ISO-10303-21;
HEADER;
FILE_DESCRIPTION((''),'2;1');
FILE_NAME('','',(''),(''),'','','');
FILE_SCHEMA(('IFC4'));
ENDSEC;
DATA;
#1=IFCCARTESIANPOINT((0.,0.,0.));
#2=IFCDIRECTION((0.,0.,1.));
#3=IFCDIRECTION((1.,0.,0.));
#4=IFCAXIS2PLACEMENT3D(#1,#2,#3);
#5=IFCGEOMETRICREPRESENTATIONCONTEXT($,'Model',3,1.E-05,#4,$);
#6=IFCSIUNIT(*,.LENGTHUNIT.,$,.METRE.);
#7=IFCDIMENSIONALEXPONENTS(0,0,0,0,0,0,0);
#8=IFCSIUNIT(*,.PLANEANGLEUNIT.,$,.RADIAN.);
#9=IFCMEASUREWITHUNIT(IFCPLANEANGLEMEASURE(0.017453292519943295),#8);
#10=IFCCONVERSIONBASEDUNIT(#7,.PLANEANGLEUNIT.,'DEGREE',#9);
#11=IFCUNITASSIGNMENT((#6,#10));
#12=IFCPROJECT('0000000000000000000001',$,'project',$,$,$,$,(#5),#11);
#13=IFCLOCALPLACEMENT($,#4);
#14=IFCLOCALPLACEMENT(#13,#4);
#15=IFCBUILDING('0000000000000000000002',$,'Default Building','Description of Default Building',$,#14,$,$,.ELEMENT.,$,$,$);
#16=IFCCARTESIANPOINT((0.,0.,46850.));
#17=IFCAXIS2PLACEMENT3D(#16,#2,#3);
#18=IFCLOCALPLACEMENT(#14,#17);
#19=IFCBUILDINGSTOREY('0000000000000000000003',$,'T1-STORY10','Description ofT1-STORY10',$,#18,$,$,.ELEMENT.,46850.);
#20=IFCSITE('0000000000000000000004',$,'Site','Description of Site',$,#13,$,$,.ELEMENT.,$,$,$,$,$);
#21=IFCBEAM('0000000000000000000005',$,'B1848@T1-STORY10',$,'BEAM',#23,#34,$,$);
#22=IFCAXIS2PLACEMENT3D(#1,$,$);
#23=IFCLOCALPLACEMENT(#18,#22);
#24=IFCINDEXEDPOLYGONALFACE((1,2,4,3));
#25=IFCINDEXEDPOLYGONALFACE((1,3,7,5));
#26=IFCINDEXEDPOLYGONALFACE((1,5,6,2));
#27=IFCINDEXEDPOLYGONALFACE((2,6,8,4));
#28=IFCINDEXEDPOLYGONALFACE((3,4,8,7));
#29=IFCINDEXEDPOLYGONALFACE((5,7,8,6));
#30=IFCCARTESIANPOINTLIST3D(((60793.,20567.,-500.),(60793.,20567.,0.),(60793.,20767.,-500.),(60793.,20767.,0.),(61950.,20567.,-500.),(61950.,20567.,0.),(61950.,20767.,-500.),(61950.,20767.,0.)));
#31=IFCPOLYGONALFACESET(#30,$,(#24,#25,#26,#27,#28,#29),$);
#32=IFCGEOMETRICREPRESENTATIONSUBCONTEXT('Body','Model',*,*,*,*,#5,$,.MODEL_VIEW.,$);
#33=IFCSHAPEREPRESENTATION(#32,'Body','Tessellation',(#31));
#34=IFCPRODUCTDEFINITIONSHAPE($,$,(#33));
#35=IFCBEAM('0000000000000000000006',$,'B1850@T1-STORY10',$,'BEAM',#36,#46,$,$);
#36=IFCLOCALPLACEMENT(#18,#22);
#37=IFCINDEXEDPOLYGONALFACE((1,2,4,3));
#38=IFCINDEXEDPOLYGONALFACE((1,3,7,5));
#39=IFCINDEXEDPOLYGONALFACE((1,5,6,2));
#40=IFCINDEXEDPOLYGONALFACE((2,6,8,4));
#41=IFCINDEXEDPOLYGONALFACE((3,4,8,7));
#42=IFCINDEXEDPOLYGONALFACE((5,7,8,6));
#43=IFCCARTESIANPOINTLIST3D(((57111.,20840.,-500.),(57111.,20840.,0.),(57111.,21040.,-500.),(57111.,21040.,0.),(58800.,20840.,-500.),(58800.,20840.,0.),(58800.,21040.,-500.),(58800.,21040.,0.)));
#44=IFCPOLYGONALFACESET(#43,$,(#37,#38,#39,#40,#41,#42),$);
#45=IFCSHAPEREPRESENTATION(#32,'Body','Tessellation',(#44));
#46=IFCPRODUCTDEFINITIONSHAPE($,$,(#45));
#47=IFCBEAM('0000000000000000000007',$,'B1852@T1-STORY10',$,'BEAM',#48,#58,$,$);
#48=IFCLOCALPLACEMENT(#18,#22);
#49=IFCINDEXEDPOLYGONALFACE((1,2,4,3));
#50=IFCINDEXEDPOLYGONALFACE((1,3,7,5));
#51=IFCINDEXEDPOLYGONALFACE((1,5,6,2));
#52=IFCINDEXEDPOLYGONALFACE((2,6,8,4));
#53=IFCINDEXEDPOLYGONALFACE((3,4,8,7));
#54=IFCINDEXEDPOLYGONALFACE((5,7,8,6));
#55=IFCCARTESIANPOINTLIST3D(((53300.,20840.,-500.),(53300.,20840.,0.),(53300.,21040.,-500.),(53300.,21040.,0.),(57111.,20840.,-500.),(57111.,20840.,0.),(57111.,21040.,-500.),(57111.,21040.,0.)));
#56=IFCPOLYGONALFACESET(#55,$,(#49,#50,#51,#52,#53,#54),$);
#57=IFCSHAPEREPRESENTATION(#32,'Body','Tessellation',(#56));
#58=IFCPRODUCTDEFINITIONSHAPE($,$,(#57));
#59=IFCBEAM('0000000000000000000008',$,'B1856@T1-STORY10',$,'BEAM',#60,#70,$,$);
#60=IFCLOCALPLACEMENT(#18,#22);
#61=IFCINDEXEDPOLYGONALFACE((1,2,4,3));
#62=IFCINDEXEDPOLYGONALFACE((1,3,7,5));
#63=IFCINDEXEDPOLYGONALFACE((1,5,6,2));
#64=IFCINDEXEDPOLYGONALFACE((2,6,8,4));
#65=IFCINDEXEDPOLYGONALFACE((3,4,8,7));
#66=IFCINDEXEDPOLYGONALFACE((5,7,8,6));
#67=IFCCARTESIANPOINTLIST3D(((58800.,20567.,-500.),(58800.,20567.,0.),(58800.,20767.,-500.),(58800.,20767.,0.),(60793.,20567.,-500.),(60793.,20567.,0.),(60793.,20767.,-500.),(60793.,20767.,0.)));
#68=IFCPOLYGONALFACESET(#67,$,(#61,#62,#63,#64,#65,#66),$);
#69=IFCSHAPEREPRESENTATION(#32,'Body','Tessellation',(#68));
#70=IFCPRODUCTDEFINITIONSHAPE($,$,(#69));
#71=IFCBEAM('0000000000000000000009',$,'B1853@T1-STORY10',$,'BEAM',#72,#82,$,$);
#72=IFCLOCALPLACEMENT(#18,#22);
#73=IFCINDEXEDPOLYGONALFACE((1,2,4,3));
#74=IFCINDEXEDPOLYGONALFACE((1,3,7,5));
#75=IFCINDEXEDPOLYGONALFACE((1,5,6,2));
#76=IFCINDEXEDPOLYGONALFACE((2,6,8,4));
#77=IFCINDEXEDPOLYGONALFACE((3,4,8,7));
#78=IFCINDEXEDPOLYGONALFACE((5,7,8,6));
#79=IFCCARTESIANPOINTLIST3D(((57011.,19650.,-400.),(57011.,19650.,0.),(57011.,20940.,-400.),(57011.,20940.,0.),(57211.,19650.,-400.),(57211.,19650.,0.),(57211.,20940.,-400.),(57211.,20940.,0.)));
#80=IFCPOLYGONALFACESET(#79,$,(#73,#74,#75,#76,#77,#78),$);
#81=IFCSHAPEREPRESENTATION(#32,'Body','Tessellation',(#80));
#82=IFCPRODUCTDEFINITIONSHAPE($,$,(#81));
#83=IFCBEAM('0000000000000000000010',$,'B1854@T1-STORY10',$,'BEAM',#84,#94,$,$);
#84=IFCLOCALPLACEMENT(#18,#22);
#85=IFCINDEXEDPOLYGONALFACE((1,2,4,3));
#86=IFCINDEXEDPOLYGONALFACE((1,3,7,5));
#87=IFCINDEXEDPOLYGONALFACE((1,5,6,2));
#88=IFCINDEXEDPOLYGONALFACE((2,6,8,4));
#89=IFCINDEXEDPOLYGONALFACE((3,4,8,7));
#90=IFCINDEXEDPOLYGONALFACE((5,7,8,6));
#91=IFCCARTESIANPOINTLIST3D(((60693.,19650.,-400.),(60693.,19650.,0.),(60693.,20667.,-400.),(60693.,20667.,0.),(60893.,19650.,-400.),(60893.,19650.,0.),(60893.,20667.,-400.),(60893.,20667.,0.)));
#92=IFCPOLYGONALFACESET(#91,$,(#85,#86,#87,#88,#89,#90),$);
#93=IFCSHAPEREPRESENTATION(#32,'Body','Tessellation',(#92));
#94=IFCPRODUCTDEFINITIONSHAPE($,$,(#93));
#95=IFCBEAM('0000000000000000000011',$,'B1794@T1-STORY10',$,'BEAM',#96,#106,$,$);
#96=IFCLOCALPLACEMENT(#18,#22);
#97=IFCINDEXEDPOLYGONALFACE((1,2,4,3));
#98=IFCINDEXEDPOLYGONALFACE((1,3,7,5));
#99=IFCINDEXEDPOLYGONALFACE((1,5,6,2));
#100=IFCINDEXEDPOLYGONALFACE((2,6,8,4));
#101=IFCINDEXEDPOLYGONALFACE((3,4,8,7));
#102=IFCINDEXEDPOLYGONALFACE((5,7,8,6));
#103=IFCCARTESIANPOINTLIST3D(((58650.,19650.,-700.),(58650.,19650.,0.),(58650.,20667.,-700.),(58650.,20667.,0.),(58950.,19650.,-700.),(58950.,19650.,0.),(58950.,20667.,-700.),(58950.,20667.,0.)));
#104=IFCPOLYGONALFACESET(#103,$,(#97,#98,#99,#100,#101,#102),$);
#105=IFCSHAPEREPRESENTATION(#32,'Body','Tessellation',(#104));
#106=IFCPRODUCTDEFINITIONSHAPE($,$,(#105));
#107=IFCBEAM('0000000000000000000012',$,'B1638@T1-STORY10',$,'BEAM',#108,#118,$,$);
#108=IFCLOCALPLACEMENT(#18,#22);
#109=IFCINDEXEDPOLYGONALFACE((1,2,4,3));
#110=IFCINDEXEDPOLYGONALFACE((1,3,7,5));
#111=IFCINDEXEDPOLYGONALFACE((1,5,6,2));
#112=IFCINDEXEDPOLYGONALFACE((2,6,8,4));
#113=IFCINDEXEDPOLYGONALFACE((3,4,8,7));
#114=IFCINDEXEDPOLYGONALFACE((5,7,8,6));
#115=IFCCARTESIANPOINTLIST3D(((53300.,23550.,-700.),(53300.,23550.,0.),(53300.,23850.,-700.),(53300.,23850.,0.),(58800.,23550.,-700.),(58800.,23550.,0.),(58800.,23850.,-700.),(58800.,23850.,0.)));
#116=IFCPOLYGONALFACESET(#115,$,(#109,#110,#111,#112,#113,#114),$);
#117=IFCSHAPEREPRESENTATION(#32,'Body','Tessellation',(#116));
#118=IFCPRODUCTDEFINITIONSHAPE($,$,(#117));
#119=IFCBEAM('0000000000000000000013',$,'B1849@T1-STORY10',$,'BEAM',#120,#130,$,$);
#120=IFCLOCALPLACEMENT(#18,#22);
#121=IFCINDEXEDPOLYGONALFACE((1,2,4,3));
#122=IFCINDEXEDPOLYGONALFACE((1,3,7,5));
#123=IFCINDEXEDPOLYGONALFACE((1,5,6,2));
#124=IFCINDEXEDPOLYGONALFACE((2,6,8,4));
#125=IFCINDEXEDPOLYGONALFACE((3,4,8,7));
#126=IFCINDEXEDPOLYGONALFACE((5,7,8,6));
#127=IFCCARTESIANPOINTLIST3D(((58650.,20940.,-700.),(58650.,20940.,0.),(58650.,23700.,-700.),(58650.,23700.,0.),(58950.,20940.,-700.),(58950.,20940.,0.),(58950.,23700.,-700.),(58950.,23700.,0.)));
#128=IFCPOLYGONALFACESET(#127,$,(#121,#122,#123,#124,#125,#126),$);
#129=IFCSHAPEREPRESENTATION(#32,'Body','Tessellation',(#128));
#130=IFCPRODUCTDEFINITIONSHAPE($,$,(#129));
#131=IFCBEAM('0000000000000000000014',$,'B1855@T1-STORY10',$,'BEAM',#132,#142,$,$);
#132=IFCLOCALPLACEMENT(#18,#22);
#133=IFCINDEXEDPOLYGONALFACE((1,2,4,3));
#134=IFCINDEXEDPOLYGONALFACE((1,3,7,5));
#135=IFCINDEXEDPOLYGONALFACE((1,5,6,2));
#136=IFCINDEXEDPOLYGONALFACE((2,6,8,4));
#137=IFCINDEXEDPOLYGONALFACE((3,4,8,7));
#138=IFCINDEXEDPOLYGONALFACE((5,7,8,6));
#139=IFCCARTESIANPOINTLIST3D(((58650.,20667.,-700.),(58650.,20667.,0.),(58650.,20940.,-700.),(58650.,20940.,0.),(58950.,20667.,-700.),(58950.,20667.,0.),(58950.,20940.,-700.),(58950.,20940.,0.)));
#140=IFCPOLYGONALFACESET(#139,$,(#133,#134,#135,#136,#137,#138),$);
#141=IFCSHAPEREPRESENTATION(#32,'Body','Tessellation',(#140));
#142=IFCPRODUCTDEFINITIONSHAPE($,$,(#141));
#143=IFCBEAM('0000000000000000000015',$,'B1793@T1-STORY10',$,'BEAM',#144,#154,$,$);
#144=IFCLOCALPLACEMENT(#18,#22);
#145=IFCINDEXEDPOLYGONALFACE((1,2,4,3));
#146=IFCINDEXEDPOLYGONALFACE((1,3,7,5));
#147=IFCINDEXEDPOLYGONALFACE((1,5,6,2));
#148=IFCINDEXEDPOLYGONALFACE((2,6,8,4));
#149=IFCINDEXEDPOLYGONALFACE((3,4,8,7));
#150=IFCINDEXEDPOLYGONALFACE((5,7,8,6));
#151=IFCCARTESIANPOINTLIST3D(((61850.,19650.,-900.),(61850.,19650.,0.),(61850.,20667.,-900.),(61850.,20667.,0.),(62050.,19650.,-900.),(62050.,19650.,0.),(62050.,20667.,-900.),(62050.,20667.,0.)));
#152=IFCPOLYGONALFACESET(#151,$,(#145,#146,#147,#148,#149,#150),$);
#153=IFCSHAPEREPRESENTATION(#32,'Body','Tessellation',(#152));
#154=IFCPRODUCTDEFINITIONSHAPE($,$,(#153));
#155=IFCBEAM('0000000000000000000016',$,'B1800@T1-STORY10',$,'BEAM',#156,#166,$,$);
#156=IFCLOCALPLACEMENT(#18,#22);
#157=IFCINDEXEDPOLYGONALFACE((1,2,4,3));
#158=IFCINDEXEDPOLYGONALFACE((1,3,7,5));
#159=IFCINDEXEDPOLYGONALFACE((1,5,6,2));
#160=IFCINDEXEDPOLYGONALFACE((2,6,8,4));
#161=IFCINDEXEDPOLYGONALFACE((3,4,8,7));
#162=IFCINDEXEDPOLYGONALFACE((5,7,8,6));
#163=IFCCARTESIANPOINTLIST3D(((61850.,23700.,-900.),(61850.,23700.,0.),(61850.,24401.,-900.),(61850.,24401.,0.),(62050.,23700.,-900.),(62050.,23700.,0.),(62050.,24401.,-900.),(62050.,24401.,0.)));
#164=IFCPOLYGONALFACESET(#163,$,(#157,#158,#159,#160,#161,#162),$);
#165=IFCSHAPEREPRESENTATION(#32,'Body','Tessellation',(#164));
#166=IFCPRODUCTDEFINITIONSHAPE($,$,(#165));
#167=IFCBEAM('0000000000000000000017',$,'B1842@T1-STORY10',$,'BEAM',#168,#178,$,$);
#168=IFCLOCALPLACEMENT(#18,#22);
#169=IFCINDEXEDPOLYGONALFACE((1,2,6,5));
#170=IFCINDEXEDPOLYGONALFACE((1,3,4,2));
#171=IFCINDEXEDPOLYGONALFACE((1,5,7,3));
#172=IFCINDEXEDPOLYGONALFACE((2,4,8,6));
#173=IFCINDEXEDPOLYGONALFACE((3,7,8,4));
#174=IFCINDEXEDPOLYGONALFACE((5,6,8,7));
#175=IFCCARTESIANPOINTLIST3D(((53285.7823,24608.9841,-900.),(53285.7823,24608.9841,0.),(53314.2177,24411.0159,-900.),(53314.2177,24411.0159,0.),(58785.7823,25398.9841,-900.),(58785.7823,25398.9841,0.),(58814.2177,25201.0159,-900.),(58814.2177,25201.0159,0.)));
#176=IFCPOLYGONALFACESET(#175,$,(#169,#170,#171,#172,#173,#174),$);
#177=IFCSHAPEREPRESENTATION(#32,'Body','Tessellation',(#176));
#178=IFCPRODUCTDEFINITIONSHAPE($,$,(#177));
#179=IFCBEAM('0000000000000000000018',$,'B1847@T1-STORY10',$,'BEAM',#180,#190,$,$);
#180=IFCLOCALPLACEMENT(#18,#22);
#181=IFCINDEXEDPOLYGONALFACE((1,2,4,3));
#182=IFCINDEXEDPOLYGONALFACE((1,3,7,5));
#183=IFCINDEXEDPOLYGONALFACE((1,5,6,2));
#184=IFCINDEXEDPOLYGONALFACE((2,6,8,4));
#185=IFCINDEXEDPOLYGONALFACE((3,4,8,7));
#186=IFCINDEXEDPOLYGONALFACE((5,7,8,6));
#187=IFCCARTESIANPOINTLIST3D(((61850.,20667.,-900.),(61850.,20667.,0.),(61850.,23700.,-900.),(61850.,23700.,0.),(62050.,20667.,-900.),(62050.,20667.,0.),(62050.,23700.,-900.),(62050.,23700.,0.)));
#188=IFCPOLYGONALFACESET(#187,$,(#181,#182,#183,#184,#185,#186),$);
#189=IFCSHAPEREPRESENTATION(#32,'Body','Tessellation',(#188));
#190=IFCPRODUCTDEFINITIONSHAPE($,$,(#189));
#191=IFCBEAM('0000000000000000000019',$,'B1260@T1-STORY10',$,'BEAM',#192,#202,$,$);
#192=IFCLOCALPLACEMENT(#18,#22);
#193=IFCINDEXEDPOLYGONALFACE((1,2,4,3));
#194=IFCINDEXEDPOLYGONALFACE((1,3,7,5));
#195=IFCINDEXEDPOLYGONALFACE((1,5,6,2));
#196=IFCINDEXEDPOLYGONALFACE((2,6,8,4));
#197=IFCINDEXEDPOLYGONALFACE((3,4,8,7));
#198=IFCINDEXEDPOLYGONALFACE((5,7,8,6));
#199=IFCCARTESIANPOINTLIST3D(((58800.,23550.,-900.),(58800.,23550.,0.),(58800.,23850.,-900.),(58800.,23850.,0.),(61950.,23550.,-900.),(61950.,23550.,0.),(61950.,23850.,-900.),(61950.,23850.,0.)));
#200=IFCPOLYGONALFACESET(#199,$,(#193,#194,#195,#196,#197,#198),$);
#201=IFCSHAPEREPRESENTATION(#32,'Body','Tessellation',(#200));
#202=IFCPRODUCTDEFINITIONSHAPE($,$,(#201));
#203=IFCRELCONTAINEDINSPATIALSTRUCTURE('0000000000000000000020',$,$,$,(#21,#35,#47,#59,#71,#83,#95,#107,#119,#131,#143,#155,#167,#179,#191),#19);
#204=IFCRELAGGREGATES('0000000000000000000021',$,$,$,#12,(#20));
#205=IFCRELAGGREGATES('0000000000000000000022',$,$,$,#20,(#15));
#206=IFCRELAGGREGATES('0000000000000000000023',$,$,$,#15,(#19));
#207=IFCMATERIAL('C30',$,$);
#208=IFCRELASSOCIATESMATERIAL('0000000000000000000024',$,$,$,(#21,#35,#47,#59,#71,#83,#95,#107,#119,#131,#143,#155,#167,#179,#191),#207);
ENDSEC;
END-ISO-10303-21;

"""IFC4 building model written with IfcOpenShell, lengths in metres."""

from ifc_helpers import new_model, entity, si_unit, converted_unit, frame, origin_with_axes, place, context, subcontext, project, spatial, rectangle, extrude, material, element, save


model = new_model("IFC4")

# Units and contexts
model_context = context("Model", 3, precision=1e-05, world=origin_with_axes())
body_context = subcontext(model_context, "Body", "Model", "MODEL_VIEW")
ifc_project = project(units=[si_unit("LENGTHUNIT", "METRE"), converted_unit("PLANEANGLEUNIT", "DEGREE", entity("IfcPlaneAngleMeasure", 0.017453292519943295), si_unit("PLANEANGLEUNIT", "RADIAN"), dimensions=[0, 0, 0, 0, 0, 0, 0])], contexts=[model_context])

# Site, building, storey
site_placement = place(None, origin_with_axes())
site = spatial("IfcSite", under=ifc_project, at=site_placement, Name="Site", Description="Description of Site", CompositionType="ELEMENT")
building_placement = place(site_placement, origin_with_axes())
building = spatial("IfcBuilding", under=site, at=building_placement, Name="Default Building", Description="Description of Default Building", CompositionType="ELEMENT")
storey_placement = place(building_placement, frame((0.0, 0.0, 46850.0), z_axis=(0.0, 0.0, 1.0), x_axis=(1.0, 0.0, 0.0)))
storey = spatial("IfcBuildingStorey", under=building, at=storey_placement, Name="T1-STORY10", Description="Description ofT1-STORY10", CompositionType="ELEMENT", Elevation=46850.0)

# Beams
ifc_material_1 = material(Name="C30")
beam_1_placement = place(storey_placement, frame((60793.0, 20667.0, -250.0), z_axis=(1.0, 0.0, 0.0), x_axis=(0.0, 1.0, 0.0)))
element("IfcBeam", 1, at=beam_1_placement, inside=storey, material=ifc_material_1, Name="B1848@T1-STORY10", ObjectType="BEAM", context=body_context, shape_type="SweptSolid", body=[
    extrude(rectangle(XDim=200.0, YDim=500.0), origin_with_axes(), (0.0, 0.0, 1.0), 1157.0),
])
beam_2_placement = place(storey_placement, frame((57111.0, 20940.0, -250.0), z_axis=(1.0, 0.0, 0.0), x_axis=(0.0, 1.0, 0.0)))
element("IfcBeam", 2, at=beam_2_placement, inside=storey, material=ifc_material_1, Name="B1850@T1-STORY10", ObjectType="BEAM", context=body_context, shape_type="SweptSolid", body=[
    extrude(rectangle(XDim=200.0, YDim=500.0), origin_with_axes(), (0.0, 0.0, 1.0), 1689.0),
])
beam_3_placement = place(storey_placement, frame((53300.0, 20940.0, -250.0), z_axis=(1.0, 0.0, 0.0), x_axis=(0.0, 1.0, 0.0)))
element("IfcBeam", 3, at=beam_3_placement, inside=storey, material=ifc_material_1, Name="B1852@T1-STORY10", ObjectType="BEAM", context=body_context, shape_type="SweptSolid", body=[
    extrude(rectangle(XDim=200.0, YDim=500.0), origin_with_axes(), (0.0, 0.0, 1.0), 3811.0),
])
beam_4_placement = place(storey_placement, frame((58800.0, 20667.0, -250.0), z_axis=(1.0, 0.0, 0.0), x_axis=(0.0, 1.0, 0.0)))
element("IfcBeam", 4, at=beam_4_placement, inside=storey, material=ifc_material_1, Name="B1856@T1-STORY10", ObjectType="BEAM", context=body_context, shape_type="SweptSolid", body=[
    extrude(rectangle(XDim=200.0, YDim=500.0), origin_with_axes(), (0.0, 0.0, 1.0), 1993.0),
])
beam_5_placement = place(storey_placement, frame((57111.0, 19650.0, -200.0), z_axis=(0.0, 1.0, 0.0), x_axis=(-1.0, 0.0, 0.0)))
element("IfcBeam", 5, at=beam_5_placement, inside=storey, material=ifc_material_1, Name="B1853@T1-STORY10", ObjectType="BEAM", context=body_context, shape_type="SweptSolid", body=[
    extrude(rectangle(XDim=200.0, YDim=400.0), origin_with_axes(), (0.0, 0.0, 1.0), 1290.0),
])
beam_6_placement = place(storey_placement, frame((60793.0, 19650.0, -200.0), z_axis=(0.0, 1.0, 0.0), x_axis=(-1.0, 0.0, 0.0)))
element("IfcBeam", 6, at=beam_6_placement, inside=storey, material=ifc_material_1, Name="B1854@T1-STORY10", ObjectType="BEAM", context=body_context, shape_type="SweptSolid", body=[
    extrude(rectangle(XDim=200.0, YDim=400.0), origin_with_axes(), (0.0, 0.0, 1.0), 1017.0),
])
beam_7_placement = place(storey_placement, frame((58800.0, 19650.0, -350.0), z_axis=(0.0, 1.0, 0.0), x_axis=(-1.0, 0.0, 0.0)))
element("IfcBeam", 7, at=beam_7_placement, inside=storey, material=ifc_material_1, Name="B1794@T1-STORY10", ObjectType="BEAM", context=body_context, shape_type="SweptSolid", body=[
    extrude(rectangle(XDim=300.0, YDim=700.0), origin_with_axes(), (0.0, 0.0, 1.0), 1017.0),
])
beam_8_placement = place(storey_placement, frame((53300.0, 23700.0, -350.0), z_axis=(1.0, 0.0, 0.0), x_axis=(0.0, 1.0, 0.0)))
element("IfcBeam", 8, at=beam_8_placement, inside=storey, material=ifc_material_1, Name="B1638@T1-STORY10", ObjectType="BEAM", context=body_context, shape_type="SweptSolid", body=[
    extrude(rectangle(XDim=300.0, YDim=700.0), origin_with_axes(), (0.0, 0.0, 1.0), 5500.0),
])
beam_9_placement = place(storey_placement, frame((58800.0, 20940.0, -350.0), z_axis=(0.0, 1.0, 0.0), x_axis=(-1.0, 0.0, 0.0)))
element("IfcBeam", 9, at=beam_9_placement, inside=storey, material=ifc_material_1, Name="B1849@T1-STORY10", ObjectType="BEAM", context=body_context, shape_type="SweptSolid", body=[
    extrude(rectangle(XDim=300.0, YDim=700.0), origin_with_axes(), (0.0, 0.0, 1.0), 2760.0),
])
beam_10_placement = place(storey_placement, frame((58800.0, 20667.0, -350.0), z_axis=(0.0, 1.0, 0.0), x_axis=(-1.0, 0.0, 0.0)))
element("IfcBeam", 10, at=beam_10_placement, inside=storey, material=ifc_material_1, Name="B1855@T1-STORY10", ObjectType="BEAM", context=body_context, shape_type="SweptSolid", body=[
    extrude(rectangle(XDim=300.0, YDim=700.0), origin_with_axes(), (0.0, 0.0, 1.0), 273.0),
])
beam_11_placement = place(storey_placement, frame((61950.0, 19650.0, -450.0), z_axis=(0.0, 1.0, 0.0), x_axis=(-1.0, 0.0, 0.0)))
element("IfcBeam", 11, at=beam_11_placement, inside=storey, material=ifc_material_1, Name="B1793@T1-STORY10", ObjectType="BEAM", context=body_context, shape_type="SweptSolid", body=[
    extrude(rectangle(XDim=200.0, YDim=900.0), origin_with_axes(), (0.0, 0.0, 1.0), 1017.0),
])
beam_12_placement = place(storey_placement, frame((61950.0, 23700.0, -450.0), z_axis=(0.0, 1.0, 0.0), x_axis=(-1.0, 0.0, 0.0)))
element("IfcBeam", 12, at=beam_12_placement, inside=storey, material=ifc_material_1, Name="B1800@T1-STORY10", ObjectType="BEAM", context=body_context, shape_type="SweptSolid", body=[
    extrude(rectangle(XDim=200.0, YDim=900.0), origin_with_axes(), (0.0, 0.0, 1.0), 701.0),
])
beam_13_placement = place(storey_placement, frame((53300.0, 24510.0, -450.0), z_axis=(0.989841, 0.142177, 0.0), x_axis=(-0.142177, 0.989841, 0.0)))
element("IfcBeam", 13, at=beam_13_placement, inside=storey, material=ifc_material_1, Name="B1842@T1-STORY10", ObjectType="BEAM", context=body_context, shape_type="SweptSolid", body=[
    extrude(rectangle(XDim=200.0, YDim=900.0), origin_with_axes(), (0.0, 0.0, 1.0), 5556.4467),
])
beam_14_placement = place(storey_placement, frame((61950.0, 20667.0, -450.0), z_axis=(0.0, 1.0, 0.0), x_axis=(-1.0, 0.0, 0.0)))
element("IfcBeam", 14, at=beam_14_placement, inside=storey, material=ifc_material_1, Name="B1847@T1-STORY10", ObjectType="BEAM", context=body_context, shape_type="SweptSolid", body=[
    extrude(rectangle(XDim=200.0, YDim=900.0), origin_with_axes(), (0.0, 0.0, 1.0), 3033.0),
])
beam_15_placement = place(storey_placement, frame((58800.0, 23700.0, -450.0), z_axis=(1.0, 0.0, 0.0), x_axis=(0.0, 1.0, 0.0)))
element("IfcBeam", 15, at=beam_15_placement, inside=storey, material=ifc_material_1, Name="B1260@T1-STORY10", ObjectType="BEAM", context=body_context, shape_type="SweptSolid", body=[
    extrude(rectangle(XDim=300.0, YDim=900.0), origin_with_axes(), (0.0, 0.0, 1.0), 3150.0),
])

save(model, "model.ifc")
